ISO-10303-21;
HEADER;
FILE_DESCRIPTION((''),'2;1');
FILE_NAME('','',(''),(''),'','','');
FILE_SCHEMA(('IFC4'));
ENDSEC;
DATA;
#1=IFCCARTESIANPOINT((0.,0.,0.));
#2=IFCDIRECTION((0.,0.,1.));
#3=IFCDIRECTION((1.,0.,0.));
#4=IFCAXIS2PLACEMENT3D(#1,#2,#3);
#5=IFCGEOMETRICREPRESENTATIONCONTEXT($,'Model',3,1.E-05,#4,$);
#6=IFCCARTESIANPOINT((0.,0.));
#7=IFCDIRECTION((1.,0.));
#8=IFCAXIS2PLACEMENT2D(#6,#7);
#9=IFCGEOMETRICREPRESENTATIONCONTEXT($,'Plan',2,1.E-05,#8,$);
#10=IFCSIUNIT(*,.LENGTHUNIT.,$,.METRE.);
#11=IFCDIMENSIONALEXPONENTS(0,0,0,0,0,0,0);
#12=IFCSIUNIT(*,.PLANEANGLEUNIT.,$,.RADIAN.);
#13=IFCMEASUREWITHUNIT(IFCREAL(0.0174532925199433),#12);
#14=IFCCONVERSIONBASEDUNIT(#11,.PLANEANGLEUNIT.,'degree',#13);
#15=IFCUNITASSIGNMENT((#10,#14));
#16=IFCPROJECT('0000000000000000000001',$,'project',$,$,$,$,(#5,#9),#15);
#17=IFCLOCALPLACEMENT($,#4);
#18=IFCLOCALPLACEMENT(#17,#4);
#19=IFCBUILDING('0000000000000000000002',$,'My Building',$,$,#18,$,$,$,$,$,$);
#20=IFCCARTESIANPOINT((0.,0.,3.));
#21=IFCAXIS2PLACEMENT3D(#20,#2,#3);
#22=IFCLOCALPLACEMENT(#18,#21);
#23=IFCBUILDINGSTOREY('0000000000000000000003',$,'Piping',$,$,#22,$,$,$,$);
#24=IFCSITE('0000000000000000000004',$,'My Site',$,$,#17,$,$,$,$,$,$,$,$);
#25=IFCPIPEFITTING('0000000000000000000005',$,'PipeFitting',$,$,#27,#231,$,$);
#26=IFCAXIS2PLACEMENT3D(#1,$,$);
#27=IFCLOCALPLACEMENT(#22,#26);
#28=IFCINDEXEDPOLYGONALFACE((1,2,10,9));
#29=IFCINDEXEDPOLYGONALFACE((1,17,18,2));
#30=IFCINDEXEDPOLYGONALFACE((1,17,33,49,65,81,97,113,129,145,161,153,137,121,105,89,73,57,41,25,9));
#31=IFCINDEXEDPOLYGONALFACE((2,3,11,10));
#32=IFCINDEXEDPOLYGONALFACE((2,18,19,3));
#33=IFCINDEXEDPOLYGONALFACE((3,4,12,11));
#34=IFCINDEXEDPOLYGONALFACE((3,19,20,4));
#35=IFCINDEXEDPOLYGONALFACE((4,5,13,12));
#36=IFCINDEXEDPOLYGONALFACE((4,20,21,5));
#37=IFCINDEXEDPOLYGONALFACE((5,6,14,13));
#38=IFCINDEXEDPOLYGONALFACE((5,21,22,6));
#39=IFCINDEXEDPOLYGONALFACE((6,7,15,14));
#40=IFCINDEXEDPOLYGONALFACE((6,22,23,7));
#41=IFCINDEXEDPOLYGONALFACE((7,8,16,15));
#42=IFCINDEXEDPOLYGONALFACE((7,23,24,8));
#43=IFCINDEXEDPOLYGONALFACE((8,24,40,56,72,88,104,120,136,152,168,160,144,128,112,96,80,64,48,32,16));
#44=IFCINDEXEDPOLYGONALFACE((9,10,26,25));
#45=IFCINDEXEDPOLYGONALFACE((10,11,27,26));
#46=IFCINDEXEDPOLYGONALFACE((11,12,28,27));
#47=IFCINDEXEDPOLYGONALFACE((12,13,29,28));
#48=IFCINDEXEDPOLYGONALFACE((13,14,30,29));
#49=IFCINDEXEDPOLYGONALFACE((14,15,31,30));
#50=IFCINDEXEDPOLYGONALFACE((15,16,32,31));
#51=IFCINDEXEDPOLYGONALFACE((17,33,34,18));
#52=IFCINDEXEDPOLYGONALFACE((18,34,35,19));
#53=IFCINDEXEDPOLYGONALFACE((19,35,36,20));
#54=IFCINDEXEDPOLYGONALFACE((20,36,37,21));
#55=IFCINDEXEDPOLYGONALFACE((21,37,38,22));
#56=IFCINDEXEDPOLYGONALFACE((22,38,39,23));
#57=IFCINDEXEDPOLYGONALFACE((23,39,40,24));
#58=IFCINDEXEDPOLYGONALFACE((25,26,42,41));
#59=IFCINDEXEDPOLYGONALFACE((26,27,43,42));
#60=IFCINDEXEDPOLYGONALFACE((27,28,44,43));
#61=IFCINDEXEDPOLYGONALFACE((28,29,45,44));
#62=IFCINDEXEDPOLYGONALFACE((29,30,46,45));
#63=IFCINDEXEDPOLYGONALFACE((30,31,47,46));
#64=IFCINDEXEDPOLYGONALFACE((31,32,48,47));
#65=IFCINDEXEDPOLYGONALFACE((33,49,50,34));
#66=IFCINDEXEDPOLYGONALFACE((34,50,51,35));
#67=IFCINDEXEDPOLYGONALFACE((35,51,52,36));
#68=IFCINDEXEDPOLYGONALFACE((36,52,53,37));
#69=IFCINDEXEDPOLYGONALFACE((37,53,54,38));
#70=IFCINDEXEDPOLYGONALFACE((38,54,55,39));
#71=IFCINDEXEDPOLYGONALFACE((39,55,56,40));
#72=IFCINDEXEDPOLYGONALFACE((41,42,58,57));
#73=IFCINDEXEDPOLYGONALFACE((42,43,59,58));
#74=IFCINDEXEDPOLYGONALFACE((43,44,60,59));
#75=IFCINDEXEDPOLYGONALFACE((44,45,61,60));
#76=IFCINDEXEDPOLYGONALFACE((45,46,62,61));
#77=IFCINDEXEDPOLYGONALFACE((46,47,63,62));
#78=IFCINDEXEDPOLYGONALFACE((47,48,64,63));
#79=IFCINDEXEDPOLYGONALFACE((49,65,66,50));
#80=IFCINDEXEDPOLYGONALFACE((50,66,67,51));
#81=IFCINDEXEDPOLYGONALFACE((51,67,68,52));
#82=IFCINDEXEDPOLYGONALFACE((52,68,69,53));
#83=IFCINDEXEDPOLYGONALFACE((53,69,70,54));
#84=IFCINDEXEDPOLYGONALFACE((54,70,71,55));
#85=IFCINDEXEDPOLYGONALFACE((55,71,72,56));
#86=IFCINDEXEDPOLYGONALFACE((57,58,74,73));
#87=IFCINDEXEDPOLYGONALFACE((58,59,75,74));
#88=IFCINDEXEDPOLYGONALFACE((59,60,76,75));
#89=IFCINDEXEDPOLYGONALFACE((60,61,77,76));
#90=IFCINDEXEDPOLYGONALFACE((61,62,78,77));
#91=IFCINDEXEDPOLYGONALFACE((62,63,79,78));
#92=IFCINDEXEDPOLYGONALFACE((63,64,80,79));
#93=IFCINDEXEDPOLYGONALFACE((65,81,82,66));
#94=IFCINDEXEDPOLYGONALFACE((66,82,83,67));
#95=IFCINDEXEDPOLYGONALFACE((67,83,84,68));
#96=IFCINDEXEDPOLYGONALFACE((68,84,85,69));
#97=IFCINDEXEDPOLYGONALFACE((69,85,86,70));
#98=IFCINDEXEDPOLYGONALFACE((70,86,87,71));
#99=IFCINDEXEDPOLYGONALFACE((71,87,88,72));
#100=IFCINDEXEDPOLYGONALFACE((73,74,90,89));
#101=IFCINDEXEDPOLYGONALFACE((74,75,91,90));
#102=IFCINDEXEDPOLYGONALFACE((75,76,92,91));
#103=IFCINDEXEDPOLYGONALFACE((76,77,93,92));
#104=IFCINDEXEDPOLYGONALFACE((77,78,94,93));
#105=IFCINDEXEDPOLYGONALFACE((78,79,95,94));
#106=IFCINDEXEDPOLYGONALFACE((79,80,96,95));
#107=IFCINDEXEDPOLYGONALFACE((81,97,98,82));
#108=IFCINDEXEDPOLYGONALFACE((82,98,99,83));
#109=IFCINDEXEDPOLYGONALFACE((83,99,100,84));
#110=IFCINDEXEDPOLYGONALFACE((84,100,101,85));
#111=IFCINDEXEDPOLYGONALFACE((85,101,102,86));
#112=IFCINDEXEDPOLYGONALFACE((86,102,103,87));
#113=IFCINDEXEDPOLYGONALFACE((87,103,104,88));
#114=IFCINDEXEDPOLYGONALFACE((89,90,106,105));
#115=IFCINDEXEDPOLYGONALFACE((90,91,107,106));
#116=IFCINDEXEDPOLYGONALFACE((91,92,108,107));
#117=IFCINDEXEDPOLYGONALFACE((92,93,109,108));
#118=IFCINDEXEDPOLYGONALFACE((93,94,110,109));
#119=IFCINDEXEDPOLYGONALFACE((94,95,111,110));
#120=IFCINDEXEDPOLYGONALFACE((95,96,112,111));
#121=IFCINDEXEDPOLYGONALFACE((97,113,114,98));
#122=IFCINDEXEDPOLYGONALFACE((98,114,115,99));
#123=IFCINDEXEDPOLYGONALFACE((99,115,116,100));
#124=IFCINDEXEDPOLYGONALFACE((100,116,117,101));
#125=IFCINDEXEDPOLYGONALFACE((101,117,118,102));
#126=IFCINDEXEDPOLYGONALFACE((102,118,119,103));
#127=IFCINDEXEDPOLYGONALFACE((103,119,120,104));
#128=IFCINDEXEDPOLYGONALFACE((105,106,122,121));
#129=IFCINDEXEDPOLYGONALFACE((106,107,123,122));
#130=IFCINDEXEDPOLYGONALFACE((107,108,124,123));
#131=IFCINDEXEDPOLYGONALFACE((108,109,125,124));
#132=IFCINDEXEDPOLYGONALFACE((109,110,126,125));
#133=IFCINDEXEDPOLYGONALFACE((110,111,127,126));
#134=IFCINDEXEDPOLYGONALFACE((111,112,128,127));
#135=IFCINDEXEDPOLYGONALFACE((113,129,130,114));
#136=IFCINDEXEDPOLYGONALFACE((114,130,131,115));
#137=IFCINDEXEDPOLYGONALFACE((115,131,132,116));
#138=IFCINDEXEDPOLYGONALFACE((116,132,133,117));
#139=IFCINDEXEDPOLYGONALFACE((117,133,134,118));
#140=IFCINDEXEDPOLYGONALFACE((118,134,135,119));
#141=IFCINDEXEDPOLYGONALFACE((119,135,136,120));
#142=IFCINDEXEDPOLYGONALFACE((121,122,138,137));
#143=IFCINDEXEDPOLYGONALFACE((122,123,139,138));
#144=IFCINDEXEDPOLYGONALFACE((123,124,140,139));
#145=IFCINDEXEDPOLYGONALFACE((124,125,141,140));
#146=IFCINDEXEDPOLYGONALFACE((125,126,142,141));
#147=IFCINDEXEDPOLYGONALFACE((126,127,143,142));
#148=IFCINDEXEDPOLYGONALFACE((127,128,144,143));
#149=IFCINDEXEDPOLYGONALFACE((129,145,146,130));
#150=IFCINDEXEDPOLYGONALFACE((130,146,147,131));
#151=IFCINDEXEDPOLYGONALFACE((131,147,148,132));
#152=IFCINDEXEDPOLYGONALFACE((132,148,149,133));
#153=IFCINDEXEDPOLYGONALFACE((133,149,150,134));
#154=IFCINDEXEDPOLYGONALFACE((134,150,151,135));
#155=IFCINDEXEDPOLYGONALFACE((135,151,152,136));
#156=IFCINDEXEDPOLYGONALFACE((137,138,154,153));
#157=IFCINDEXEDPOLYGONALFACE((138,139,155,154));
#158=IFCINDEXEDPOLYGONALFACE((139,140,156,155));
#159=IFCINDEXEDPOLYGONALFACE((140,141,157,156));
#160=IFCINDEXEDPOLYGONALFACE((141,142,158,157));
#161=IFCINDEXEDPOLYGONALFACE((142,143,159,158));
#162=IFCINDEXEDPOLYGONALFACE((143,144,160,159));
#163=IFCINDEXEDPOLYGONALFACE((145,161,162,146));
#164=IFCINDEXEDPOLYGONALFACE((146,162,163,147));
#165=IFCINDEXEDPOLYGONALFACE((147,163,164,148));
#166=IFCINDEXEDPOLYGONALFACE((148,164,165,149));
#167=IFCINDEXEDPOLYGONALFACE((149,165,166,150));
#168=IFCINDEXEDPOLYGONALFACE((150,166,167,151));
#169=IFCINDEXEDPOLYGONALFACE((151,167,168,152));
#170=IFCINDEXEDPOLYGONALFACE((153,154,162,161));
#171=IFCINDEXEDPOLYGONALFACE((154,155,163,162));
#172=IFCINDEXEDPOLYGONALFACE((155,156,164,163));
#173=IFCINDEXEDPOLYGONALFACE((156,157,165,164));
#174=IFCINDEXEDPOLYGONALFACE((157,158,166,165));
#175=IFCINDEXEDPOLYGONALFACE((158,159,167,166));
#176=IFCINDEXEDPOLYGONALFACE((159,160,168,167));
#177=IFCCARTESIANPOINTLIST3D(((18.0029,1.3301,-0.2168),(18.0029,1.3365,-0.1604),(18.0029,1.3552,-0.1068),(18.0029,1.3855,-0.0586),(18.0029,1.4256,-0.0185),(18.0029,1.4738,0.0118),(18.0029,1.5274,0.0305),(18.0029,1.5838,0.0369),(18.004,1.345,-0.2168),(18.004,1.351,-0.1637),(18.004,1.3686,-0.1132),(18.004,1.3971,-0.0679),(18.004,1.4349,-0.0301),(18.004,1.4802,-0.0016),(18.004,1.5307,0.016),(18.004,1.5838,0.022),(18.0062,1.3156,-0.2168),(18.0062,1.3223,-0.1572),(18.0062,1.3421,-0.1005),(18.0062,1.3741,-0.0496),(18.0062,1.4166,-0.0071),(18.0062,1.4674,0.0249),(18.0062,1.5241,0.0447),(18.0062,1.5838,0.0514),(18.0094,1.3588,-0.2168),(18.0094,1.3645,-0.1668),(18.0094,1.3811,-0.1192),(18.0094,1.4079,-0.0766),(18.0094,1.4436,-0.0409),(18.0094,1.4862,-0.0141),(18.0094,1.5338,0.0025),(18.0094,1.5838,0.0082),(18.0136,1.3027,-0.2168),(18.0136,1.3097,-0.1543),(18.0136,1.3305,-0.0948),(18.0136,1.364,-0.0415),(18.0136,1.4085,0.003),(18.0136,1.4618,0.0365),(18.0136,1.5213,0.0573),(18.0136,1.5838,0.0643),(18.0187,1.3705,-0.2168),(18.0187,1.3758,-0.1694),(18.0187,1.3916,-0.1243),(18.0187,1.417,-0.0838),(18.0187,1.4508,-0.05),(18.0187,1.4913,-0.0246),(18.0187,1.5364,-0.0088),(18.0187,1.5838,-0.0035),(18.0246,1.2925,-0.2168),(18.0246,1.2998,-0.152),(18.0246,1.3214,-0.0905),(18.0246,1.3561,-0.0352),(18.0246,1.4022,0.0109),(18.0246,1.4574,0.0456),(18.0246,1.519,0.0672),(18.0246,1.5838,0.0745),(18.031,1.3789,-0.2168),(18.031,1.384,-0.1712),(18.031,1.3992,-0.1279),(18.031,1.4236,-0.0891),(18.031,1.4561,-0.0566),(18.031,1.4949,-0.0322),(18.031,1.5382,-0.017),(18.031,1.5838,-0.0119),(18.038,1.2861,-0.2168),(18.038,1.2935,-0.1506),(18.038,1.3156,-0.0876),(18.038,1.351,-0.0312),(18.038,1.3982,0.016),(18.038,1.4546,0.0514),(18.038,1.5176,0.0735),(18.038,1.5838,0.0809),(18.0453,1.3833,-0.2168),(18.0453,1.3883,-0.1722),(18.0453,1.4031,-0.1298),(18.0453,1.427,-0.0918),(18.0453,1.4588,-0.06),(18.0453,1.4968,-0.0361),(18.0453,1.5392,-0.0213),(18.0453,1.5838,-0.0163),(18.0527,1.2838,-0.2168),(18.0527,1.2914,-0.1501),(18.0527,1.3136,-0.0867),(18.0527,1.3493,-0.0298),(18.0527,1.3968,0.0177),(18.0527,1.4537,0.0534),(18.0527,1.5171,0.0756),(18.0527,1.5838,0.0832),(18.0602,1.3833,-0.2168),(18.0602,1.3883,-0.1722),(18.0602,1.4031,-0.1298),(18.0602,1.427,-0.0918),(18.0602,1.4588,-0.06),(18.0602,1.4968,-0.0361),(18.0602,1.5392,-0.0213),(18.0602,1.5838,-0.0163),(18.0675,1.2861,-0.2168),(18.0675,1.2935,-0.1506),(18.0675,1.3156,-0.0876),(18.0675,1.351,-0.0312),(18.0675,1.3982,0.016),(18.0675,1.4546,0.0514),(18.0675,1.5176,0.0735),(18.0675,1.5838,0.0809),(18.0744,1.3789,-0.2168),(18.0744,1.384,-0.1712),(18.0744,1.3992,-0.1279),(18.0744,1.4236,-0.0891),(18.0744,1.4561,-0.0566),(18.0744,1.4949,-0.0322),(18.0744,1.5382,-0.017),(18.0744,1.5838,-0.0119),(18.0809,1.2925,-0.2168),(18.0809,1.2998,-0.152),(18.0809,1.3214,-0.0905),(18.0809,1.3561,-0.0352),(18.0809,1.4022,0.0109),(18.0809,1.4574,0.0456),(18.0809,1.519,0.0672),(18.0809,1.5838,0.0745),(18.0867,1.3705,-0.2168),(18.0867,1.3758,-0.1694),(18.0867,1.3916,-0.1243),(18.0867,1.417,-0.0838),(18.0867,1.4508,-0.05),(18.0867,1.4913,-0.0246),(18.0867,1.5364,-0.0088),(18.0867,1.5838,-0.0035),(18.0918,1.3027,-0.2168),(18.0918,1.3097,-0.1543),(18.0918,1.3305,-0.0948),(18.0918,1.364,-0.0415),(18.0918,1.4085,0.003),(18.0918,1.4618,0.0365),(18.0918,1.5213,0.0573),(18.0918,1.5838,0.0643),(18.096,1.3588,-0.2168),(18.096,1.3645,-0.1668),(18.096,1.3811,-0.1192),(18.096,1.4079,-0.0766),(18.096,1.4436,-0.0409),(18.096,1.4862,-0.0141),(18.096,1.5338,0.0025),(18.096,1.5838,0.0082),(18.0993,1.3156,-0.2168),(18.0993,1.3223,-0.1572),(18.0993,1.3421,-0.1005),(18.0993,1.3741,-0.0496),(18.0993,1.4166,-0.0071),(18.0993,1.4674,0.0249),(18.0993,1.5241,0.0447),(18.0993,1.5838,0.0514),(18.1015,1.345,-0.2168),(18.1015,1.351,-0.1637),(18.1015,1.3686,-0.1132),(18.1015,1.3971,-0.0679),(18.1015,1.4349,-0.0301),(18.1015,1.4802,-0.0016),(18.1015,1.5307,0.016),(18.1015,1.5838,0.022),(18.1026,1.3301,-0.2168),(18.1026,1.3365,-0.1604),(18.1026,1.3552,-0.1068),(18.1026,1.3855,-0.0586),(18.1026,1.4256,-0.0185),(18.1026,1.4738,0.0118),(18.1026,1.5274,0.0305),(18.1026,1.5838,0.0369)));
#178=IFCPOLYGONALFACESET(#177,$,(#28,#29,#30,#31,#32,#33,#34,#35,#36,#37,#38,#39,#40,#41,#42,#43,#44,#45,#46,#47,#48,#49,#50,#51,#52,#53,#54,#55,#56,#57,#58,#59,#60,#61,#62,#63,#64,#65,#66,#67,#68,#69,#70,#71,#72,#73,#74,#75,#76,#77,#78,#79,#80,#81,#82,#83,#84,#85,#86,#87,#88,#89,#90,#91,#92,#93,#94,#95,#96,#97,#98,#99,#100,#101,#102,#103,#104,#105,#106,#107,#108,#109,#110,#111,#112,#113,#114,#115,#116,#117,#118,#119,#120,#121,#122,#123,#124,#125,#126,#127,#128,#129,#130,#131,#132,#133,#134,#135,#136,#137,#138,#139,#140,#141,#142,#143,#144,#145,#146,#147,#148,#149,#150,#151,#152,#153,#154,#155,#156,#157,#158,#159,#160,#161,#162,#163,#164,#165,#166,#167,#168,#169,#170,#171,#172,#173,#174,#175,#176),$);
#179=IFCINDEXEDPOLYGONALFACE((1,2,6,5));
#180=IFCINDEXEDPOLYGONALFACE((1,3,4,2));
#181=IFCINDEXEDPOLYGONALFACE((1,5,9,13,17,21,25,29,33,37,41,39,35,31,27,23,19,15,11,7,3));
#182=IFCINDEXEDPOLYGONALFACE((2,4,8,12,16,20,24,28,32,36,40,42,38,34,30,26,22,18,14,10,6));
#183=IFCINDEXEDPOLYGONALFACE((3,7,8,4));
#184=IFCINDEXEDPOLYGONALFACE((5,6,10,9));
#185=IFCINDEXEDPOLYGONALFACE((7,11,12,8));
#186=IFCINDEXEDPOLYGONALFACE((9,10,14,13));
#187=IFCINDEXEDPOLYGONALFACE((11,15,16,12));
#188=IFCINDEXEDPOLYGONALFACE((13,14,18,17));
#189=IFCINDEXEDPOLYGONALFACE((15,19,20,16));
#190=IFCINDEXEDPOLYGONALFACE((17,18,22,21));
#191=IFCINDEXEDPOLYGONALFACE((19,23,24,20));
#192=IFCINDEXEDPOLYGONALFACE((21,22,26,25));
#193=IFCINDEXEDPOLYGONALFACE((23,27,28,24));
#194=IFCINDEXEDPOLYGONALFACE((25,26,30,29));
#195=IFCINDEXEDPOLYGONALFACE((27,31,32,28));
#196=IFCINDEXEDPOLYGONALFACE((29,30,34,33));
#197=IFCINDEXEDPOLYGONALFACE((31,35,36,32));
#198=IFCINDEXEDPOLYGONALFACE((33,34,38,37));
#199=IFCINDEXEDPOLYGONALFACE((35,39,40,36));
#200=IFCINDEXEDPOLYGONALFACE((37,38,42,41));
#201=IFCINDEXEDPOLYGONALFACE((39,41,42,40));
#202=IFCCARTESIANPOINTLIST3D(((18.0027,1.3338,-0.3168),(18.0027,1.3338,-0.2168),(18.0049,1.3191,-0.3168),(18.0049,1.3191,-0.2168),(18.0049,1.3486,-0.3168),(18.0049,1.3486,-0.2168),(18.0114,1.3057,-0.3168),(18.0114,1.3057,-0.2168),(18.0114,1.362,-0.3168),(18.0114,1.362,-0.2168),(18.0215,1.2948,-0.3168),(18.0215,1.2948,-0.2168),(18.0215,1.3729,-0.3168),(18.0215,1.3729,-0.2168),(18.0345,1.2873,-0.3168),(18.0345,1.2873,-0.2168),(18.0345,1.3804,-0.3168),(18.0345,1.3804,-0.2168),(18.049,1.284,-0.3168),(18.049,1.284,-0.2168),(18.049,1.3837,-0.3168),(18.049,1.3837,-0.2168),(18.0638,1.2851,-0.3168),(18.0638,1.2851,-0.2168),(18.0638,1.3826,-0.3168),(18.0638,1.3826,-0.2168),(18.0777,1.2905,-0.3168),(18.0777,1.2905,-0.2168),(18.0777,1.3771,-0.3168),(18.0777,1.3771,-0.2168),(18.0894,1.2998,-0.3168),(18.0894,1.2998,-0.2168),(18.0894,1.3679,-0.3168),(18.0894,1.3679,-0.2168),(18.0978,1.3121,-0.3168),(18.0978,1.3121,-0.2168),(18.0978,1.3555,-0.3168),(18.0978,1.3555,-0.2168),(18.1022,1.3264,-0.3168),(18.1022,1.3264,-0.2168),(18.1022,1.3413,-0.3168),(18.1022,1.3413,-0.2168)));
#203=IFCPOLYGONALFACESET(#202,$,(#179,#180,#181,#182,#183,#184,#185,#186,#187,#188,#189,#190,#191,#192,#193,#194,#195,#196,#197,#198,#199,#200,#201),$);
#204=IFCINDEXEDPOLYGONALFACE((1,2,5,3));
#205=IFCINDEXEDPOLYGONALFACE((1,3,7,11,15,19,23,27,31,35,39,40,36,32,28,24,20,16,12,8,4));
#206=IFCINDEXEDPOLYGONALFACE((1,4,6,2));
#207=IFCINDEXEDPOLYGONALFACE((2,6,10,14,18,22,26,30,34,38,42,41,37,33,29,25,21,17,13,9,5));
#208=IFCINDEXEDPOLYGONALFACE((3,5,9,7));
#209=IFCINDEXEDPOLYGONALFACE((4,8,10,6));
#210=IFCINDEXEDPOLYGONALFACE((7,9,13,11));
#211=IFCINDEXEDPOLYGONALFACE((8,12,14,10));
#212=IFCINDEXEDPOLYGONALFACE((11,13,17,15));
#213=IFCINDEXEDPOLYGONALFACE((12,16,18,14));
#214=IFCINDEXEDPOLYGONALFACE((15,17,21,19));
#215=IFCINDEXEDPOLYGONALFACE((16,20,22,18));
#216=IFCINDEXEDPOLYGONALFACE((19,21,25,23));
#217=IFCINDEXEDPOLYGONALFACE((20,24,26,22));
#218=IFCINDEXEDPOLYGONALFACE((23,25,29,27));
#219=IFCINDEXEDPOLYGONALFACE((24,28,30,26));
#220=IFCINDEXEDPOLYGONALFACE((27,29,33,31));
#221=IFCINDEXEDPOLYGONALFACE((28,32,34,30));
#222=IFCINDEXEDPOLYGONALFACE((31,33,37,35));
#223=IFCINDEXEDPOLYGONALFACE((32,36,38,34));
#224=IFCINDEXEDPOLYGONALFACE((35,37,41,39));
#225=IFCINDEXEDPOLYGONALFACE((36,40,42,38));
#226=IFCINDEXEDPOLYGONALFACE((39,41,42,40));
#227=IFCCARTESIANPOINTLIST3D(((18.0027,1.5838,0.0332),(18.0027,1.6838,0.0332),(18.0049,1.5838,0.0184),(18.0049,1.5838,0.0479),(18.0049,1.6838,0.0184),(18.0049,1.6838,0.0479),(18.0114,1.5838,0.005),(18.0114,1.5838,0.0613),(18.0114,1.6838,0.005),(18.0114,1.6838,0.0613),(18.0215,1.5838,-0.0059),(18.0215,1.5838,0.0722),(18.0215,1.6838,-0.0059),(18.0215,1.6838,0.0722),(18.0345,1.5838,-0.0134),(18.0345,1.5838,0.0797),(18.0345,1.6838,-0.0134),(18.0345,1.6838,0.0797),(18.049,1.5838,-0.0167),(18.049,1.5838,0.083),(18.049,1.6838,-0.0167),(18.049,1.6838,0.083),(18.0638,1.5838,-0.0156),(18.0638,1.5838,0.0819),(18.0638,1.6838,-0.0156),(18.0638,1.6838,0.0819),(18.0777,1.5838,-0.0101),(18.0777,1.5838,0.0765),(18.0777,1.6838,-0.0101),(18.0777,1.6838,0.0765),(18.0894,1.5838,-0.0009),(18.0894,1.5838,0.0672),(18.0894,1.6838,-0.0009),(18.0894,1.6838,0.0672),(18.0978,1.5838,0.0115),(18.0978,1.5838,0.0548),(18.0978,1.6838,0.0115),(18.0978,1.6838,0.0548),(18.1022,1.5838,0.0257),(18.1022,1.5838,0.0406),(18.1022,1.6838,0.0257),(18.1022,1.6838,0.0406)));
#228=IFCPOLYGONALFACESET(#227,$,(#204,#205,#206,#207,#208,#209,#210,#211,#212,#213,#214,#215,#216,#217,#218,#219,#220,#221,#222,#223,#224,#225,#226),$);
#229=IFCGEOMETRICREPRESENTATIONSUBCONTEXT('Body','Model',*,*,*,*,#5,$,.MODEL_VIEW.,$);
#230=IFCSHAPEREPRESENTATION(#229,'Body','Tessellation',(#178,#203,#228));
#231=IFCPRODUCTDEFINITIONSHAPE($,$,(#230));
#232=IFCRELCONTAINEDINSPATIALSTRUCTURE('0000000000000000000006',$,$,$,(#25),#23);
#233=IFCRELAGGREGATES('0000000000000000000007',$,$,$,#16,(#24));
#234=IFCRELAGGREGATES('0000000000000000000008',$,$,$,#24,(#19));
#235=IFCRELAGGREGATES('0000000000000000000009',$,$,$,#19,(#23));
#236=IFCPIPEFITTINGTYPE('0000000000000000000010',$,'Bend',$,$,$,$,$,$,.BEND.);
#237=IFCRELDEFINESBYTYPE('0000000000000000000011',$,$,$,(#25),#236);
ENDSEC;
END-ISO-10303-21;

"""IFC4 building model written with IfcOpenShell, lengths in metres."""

from ifc_helpers import new_model, entity, si_unit, converted_unit, frame, origin_with_axes, origin_2d_with_axis, place, context, subcontext, project, spatial, circle, extrude, source, transform, mapped, type_object, type_shapes, element, save


model = new_model("IFC4")

# Units and contexts
model_context = context("Model", 3, precision=1e-05, world=origin_with_axes())
plan_context = context("Plan", 2, precision=1e-05, world=origin_2d_with_axis())
body_context = subcontext(model_context, "Body", "Model", "MODEL_VIEW")
ifc_project = project(units=[si_unit("LENGTHUNIT", "METRE"), converted_unit("PLANEANGLEUNIT", "degree", entity("IfcReal", 0.0174532925199433), si_unit("PLANEANGLEUNIT", "RADIAN"), dimensions=[0, 0, 0, 0, 0, 0, 0])], contexts=[model_context, plan_context])

# Site, building, storey
site_placement = place(None, origin_with_axes())
site = spatial("IfcSite", under=ifc_project, at=site_placement, Name="My Site")
building_placement = place(site_placement, origin_with_axes())
building = spatial("IfcBuilding", under=site, at=building_placement, Name="My Building")
storey_placement = place(building_placement, frame((0.0, 0.0, 3.0), z_axis=(0.0, 0.0, 1.0), x_axis=(1.0, 0.0, 0.0)))
storey = spatial("IfcBuildingStorey", under=building, at=storey_placement, Name="Piping")

# Pipe fitting
pipe_fitting_type = type_object("IfcPipeFittingType", Name="Bend", PredefinedType="BEND")
shared_shape = source(origin_with_axes(), body_context, "Body", "SolidModel", [
    entity("IfcSweptDiskSolid", entity("IfcIndexedPolyCurve", entity("IfcCartesianPointList3D", [[0.0, 0.0, -0.1], [0.0, 0.0732, -0.2768], [0.0, 0.25, -0.35]]), [entity("IfcArcIndex", [1, 2, 3])]), 0.05),
    extrude(circle(Radius=0.05), origin_with_axes(), (0.0, 0.0, -1.0), 0.1),
    extrude(circle(Radius=0.05), frame((0.0, 0.25, -0.35), z_axis=(0.0, 1.0, 0.0), x_axis=(1.0, 0.0, 0.0)), (0.0, 0.0, 1.0), 0.1),
])
type_shapes(pipe_fitting_type, [shared_shape])
for number, where, z_axis, x_axis, name in (
    (1, (18.0527, 1.3338, -0.3168), (0.0, 0.0, -1.0), (-1.0, 0.0, 0.0), "PipeFitting"),
):
    element("IfcPipeFitting", number, at=place(storey_placement, frame(where, z_axis=z_axis, x_axis=x_axis)), inside=storey, type_object=pipe_fitting_type, Name=name, context=body_context, shape_type="MappedRepresentation", body=[
        mapped(shared_shape, transform((0.0, 0.0, 0.0), x_axis=(1.0, 0.0, 0.0), y_axis=(0.0, 1.0, 0.0), z_axis=(0.0, 0.0, 1.0), scale=1.0)),
    ])

save(model, "model.ifc")
